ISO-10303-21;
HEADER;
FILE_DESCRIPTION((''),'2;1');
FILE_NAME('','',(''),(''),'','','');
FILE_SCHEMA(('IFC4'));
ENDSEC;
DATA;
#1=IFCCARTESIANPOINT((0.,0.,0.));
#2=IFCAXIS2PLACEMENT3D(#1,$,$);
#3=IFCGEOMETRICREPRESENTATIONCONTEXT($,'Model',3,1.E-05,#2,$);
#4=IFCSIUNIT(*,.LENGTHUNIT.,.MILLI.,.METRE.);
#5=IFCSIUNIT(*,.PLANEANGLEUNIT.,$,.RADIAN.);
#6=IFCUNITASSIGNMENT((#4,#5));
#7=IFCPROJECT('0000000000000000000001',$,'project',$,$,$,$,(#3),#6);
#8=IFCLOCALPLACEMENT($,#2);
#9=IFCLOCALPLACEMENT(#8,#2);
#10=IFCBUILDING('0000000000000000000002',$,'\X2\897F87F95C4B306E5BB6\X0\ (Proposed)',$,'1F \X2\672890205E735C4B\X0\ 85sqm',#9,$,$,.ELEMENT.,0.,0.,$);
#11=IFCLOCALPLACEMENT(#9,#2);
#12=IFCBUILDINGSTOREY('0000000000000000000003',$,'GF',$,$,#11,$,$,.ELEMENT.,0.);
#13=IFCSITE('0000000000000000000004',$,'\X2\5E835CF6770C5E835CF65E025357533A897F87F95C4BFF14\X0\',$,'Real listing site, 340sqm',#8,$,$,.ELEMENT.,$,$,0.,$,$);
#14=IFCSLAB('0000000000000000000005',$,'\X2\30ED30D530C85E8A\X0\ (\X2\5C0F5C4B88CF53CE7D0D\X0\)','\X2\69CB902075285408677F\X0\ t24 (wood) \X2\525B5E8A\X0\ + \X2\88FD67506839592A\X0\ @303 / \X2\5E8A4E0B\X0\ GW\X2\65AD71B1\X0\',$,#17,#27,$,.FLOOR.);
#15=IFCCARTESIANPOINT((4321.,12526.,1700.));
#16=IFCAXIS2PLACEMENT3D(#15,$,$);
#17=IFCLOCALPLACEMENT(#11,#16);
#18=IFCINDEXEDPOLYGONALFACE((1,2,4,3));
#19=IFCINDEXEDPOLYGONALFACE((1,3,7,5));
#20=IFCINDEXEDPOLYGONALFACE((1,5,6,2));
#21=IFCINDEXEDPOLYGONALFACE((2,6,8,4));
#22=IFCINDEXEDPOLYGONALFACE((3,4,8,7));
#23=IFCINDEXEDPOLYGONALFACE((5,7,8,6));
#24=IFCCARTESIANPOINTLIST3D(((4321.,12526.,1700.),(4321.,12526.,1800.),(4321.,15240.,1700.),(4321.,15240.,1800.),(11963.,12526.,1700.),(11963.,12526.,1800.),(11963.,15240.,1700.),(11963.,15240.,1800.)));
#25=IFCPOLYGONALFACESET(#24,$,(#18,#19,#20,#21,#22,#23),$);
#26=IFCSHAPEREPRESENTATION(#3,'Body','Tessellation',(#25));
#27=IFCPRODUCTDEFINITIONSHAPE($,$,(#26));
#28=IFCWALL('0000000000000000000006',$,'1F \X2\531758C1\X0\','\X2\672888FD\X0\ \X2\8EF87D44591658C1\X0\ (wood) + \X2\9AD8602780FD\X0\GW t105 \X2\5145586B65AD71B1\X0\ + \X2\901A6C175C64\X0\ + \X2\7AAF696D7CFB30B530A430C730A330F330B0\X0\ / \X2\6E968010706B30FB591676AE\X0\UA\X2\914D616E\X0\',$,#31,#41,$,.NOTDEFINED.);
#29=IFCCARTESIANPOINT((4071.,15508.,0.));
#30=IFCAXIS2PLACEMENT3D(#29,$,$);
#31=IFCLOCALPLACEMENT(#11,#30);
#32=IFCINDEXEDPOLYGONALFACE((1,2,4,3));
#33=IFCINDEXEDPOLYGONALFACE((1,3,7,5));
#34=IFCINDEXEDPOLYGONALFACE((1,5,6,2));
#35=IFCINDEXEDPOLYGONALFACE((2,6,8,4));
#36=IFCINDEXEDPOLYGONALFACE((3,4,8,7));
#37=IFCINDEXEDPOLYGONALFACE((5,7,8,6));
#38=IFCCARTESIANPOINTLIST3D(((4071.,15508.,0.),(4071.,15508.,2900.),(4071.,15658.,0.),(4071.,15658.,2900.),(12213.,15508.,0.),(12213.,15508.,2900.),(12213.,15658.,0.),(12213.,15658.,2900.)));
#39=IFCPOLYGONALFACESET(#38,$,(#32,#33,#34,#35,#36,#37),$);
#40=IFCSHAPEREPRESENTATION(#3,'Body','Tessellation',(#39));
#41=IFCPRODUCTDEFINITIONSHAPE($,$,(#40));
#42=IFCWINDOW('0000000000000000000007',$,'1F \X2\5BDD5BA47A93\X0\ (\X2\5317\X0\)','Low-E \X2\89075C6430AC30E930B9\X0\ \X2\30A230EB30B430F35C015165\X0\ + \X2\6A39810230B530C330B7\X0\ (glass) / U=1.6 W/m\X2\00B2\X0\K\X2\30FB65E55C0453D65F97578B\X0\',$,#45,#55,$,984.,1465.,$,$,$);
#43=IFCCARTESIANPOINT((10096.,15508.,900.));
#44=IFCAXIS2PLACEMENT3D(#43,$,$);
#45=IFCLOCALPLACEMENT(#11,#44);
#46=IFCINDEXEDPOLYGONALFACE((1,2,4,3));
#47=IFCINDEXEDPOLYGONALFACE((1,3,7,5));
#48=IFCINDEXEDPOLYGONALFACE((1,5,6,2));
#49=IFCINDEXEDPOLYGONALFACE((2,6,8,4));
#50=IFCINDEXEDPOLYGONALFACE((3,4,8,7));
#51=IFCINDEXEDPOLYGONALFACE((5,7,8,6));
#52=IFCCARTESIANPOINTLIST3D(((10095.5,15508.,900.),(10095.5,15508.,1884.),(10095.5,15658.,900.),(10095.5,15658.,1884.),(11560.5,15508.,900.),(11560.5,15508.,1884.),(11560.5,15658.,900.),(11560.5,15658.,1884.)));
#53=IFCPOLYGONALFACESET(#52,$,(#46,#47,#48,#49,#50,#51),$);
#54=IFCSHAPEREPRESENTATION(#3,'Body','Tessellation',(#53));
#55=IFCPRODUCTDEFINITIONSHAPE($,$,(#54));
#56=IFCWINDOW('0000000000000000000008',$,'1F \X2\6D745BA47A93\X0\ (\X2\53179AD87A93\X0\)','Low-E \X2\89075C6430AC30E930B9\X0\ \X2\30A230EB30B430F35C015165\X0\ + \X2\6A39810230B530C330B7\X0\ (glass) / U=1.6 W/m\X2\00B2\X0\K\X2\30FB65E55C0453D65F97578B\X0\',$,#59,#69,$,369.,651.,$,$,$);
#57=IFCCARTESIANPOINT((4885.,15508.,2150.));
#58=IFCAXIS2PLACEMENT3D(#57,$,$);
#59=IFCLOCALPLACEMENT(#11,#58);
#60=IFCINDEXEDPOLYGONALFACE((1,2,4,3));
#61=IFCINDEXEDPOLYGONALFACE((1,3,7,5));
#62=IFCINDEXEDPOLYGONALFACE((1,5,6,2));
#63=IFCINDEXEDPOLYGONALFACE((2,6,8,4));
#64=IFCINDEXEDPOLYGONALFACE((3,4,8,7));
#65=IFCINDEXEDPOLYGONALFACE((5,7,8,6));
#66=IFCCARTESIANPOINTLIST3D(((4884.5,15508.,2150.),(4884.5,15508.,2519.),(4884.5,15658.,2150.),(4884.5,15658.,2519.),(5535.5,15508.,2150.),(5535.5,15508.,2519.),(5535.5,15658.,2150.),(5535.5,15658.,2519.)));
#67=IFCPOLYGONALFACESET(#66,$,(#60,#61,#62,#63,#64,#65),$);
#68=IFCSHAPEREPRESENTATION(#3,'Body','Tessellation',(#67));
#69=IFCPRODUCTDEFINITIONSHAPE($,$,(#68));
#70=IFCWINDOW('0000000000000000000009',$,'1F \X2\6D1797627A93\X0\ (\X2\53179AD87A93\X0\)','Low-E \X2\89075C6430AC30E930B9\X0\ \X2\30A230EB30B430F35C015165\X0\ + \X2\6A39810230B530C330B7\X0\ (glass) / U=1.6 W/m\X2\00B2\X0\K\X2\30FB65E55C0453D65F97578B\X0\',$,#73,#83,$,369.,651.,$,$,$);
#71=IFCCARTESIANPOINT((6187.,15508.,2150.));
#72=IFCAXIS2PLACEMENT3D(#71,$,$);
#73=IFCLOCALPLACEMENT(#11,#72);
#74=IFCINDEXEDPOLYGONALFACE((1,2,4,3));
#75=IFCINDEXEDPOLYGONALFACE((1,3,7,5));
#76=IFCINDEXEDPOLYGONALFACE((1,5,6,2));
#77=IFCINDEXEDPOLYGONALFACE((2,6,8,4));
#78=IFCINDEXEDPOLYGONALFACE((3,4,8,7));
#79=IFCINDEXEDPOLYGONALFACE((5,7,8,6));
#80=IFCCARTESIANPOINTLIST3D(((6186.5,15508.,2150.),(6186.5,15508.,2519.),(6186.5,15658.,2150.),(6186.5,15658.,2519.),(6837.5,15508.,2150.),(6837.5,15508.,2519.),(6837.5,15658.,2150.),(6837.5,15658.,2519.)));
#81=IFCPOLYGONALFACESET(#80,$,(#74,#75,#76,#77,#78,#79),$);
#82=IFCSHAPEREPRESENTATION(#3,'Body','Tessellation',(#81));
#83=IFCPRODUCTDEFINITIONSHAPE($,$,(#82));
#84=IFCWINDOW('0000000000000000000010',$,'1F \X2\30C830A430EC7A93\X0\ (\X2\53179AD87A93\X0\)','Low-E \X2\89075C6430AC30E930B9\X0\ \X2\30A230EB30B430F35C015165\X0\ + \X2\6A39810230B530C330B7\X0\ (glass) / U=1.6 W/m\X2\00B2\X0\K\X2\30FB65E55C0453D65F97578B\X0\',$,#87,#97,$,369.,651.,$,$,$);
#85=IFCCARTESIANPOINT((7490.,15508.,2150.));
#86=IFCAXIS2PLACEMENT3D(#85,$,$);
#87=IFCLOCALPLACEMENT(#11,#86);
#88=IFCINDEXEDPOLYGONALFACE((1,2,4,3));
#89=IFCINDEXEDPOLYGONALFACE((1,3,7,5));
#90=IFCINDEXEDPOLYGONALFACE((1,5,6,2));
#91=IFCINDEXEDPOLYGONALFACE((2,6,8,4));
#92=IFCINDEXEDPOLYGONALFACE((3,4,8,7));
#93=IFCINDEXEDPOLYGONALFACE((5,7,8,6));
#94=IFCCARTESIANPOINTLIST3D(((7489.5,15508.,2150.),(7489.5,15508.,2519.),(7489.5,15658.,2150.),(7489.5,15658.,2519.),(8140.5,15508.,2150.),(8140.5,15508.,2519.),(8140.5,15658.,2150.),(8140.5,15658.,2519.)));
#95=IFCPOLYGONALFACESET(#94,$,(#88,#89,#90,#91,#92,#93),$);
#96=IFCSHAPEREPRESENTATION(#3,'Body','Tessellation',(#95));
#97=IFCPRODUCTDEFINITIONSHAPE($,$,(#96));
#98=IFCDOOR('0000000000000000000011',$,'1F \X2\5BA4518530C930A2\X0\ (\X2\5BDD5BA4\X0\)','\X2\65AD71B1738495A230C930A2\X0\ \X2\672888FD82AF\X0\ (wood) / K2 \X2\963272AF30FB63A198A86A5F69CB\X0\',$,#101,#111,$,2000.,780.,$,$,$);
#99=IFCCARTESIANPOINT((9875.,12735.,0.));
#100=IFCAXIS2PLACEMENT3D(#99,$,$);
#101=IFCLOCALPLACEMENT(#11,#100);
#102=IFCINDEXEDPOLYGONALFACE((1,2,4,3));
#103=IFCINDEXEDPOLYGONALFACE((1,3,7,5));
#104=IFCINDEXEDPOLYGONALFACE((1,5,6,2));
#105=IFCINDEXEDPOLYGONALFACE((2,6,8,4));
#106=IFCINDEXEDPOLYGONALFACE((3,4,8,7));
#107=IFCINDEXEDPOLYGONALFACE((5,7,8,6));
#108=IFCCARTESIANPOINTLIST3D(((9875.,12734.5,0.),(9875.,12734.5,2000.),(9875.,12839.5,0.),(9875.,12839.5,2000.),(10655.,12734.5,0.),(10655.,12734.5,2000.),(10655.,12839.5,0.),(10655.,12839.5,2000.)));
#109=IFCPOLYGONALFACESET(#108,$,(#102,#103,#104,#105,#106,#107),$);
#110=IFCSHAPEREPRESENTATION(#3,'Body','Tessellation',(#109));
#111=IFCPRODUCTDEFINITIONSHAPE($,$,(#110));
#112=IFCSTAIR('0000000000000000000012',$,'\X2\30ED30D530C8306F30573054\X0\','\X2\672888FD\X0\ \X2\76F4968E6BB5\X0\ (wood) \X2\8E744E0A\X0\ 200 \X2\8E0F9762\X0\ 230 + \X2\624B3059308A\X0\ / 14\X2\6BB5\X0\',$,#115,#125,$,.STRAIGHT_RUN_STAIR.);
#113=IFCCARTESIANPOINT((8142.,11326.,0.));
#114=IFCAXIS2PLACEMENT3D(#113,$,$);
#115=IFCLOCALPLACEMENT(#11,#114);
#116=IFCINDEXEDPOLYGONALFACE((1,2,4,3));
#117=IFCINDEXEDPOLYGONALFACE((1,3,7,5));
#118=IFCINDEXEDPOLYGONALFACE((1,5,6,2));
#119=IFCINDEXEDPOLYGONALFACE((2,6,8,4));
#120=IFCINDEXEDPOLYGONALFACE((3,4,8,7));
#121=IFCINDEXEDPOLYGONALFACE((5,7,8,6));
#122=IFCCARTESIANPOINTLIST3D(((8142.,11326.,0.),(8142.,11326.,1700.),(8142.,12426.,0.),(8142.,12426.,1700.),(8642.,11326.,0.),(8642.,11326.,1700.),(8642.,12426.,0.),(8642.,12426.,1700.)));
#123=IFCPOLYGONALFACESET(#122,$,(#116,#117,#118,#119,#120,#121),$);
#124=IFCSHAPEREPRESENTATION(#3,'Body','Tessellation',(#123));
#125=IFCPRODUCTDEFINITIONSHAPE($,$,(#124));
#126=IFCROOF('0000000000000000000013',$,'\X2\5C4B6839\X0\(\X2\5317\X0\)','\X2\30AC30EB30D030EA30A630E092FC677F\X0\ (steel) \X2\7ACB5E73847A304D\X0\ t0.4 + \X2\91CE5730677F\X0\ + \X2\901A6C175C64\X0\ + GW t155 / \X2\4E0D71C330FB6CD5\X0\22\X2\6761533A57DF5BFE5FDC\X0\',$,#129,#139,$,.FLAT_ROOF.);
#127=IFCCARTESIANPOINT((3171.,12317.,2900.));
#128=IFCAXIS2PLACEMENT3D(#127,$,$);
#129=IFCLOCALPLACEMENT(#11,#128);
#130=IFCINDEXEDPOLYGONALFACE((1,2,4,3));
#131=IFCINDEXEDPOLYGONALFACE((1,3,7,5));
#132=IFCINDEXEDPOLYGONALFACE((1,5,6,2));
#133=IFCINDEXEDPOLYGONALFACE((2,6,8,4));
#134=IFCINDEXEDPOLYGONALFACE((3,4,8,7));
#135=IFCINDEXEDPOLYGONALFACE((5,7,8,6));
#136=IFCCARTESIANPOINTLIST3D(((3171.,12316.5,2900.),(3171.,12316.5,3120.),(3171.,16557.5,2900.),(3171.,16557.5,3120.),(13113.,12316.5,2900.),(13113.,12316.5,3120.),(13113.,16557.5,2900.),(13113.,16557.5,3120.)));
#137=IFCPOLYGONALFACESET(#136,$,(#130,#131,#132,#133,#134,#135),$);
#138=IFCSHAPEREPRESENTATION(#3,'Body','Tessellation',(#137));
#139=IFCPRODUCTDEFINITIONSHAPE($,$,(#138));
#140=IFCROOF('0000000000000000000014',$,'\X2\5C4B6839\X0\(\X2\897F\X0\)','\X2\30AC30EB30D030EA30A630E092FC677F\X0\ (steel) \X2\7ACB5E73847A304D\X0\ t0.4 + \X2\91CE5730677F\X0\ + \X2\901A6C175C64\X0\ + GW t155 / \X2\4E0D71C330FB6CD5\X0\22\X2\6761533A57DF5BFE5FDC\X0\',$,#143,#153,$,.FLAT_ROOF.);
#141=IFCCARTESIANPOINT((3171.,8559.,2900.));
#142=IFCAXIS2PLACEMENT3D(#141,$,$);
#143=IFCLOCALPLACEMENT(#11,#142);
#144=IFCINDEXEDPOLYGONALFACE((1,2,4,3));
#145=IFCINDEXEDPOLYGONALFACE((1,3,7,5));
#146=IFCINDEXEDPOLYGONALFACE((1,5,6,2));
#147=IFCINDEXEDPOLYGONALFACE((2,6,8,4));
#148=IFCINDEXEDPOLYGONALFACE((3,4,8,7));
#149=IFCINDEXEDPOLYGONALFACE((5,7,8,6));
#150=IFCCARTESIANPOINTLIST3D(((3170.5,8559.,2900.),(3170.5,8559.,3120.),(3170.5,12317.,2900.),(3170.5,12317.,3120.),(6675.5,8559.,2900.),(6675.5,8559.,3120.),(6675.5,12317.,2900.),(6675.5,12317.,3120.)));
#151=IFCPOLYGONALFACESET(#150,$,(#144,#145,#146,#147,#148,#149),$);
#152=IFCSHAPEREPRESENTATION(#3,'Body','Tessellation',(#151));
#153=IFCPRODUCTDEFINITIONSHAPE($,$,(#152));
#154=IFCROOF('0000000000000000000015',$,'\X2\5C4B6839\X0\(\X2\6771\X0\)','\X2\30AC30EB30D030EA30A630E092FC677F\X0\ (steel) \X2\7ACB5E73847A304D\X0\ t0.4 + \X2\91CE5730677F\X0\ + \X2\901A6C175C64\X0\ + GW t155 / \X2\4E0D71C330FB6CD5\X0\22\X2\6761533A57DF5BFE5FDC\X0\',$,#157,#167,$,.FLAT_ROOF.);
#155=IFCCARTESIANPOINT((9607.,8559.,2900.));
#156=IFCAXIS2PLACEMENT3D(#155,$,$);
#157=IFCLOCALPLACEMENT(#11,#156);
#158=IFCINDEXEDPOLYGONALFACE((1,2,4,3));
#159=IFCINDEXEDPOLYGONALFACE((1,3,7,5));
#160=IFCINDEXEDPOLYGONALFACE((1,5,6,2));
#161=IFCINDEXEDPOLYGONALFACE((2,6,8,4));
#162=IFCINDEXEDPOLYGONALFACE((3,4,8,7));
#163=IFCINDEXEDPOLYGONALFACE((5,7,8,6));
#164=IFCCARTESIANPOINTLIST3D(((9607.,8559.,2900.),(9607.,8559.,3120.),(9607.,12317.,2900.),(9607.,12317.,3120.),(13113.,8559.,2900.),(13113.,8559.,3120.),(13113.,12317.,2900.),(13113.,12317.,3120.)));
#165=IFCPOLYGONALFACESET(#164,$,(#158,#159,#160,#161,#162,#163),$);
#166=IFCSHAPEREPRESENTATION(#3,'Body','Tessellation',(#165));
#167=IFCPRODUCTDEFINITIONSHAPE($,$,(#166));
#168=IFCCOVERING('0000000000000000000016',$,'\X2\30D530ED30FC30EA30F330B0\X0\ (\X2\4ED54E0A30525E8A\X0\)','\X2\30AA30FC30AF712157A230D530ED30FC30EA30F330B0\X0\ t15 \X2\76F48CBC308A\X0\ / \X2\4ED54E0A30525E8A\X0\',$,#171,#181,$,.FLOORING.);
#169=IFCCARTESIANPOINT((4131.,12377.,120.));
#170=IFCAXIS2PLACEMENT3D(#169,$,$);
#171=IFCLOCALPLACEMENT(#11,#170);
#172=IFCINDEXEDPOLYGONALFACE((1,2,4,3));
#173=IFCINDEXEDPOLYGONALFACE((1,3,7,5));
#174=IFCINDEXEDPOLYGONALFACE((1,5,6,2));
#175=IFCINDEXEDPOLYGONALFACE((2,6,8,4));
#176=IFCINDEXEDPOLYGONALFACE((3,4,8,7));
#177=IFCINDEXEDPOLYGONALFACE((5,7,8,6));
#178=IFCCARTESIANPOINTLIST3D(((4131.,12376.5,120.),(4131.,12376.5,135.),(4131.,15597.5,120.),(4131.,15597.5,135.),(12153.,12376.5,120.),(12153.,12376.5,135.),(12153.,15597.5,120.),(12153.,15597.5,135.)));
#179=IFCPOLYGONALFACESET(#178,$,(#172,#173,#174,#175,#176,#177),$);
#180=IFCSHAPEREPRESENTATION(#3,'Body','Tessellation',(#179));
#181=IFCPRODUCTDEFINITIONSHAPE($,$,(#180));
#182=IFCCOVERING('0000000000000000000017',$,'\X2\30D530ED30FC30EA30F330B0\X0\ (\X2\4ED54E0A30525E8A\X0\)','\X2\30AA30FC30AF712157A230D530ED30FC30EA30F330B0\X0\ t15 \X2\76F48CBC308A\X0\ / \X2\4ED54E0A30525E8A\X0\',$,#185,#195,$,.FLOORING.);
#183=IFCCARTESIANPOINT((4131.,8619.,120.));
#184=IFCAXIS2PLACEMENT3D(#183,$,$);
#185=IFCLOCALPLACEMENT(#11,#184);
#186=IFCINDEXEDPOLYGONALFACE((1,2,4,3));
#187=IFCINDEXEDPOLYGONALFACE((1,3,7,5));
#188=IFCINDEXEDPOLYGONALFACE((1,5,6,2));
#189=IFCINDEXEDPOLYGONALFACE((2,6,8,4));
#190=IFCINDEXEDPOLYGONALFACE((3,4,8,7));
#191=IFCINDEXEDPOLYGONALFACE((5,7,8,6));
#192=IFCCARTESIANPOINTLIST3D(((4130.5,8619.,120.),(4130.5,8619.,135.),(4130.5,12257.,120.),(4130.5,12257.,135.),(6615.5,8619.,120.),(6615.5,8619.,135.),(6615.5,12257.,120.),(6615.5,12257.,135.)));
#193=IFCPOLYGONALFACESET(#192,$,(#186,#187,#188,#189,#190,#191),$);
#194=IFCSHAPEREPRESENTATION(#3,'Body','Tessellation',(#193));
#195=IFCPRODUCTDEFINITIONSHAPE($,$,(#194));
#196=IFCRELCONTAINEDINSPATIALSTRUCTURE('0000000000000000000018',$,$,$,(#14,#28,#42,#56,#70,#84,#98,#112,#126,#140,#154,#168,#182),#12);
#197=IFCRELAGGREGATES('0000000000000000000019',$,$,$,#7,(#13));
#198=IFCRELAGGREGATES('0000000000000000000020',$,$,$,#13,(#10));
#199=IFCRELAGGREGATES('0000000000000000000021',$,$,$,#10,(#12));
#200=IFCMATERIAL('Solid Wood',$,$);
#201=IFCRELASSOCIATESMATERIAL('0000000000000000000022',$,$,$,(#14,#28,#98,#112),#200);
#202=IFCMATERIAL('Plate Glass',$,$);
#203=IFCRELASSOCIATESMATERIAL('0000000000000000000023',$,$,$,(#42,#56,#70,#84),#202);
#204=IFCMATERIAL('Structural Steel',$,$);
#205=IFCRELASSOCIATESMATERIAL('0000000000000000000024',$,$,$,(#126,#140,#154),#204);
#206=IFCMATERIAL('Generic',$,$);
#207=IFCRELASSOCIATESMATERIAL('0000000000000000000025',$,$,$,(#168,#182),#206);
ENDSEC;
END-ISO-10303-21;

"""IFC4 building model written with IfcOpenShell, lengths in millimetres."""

from ifc_helpers import new_model, si_unit, frame, frame_2d, origin, place, context, project, spatial, rectangle, extrude, material, element, fill, save


model = new_model("IFC4")

# Units and contexts
model_context = context("Model", 3, precision=1e-05, world=origin())
ifc_project = project(units=[si_unit("LENGTHUNIT", "METRE", prefix="MILLI"), si_unit("PLANEANGLEUNIT", "RADIAN")], contexts=[model_context])

# Site, building, storey
site_placement = place(None, origin())
site = spatial("IfcSite", under=ifc_project, at=site_placement, Name="広島県広島市南区西蟹屋４", ObjectType="Real listing site, 340sqm", CompositionType="ELEMENT", RefElevation=0.0)
building_placement = place(site_placement, origin())
building = spatial("IfcBuilding", under=site, at=building_placement, Name="西蟹屋の家 (Proposed)", ObjectType="1F 木造平屋 85sqm", CompositionType="ELEMENT", ElevationOfRefHeight=0.0, ElevationOfTerrain=0.0)
storey_placement = place(building_placement, origin())
storey = spatial("IfcBuildingStorey", under=building, at=storey_placement, Name="GF", CompositionType="ELEMENT", Elevation=0.0)

# Slab
ifc_material_1 = material(Name="Solid Wood")
slab_1_placement = place(storey_placement, frame((4321.0, 12526.0, 1700.0)))
element("IfcSlab", 1, at=slab_1_placement, inside=storey, material=ifc_material_1, Name="ロフト床 (小屋裏収納)", Description="構造用合板 t24 (wood) 剛床 + 製材根太 @303 / 床下 GW断熱", PredefinedType="FLOOR", context=model_context, shape_type="SweptSolid", body=[
    extrude(rectangle(XDim=7642.0, YDim=2714.0, at=frame_2d((3821.0, 1357.0))), frame((4321.0, 12526.0, 1700.0)), (0.0, 0.0, 1.0), 100.0),
])

# Wall, openings, windows
wall_1_placement = place(storey_placement, frame((4071.0, 15508.0, 0.0)))
wall_1 = element("IfcWall", 2, at=wall_1_placement, inside=storey, material=ifc_material_1, Name="1F 北壁", Description="木製 軸組外壁 (wood) + 高性能GW t105 充填断熱 + 通気層 + 窯業系サイディング / 準耐火・外皮UA配慮", PredefinedType="NOTDEFINED", context=model_context, shape_type="SweptSolid", body=[
    extrude(rectangle(XDim=8142.0, YDim=150.0, at=frame_2d((4071.0, 75.0))), frame((4071.0, 15508.0, 0.0)), (0.0, 0.0, 1.0), 2900.0),
])
opening_1_placement = place(storey_placement, frame((10096.0, 15508.0, 900.0)))
opening_1 = element("IfcOpeningElement", 3, at=opening_1_placement, cuts=wall_1, PredefinedType="NOTDEFINED", context=model_context, shape_type="SweptSolid", body=[
    extrude(rectangle(XDim=1465.0, YDim=150.0, at=frame_2d((732.0, 75.0))), frame((10096.0, 15508.0, 900.0)), (0.0, 0.0, 1.0), 984.0),
])
opening_2_placement = place(storey_placement, frame((4885.0, 15508.0, 2150.0)))
opening_2 = element("IfcOpeningElement", 4, at=opening_2_placement, cuts=wall_1, PredefinedType="NOTDEFINED", context=model_context, shape_type="SweptSolid", body=[
    extrude(rectangle(XDim=651.0, YDim=150.0, at=frame_2d((325.0, 75.0))), frame((4885.0, 15508.0, 2150.0)), (0.0, 0.0, 1.0), 369.0),
])
opening_3_placement = place(storey_placement, frame((6187.0, 15508.0, 2150.0)))
opening_3 = element("IfcOpeningElement", 5, at=opening_3_placement, cuts=wall_1, PredefinedType="NOTDEFINED", context=model_context, shape_type="SweptSolid", body=[
    extrude(rectangle(XDim=651.0, YDim=150.0, at=frame_2d((325.0, 75.0))), frame((6187.0, 15508.0, 2150.0)), (0.0, 0.0, 1.0), 369.0),
])
opening_4_placement = place(storey_placement, frame((7490.0, 15508.0, 2150.0)))
opening_4 = element("IfcOpeningElement", 6, at=opening_4_placement, cuts=wall_1, PredefinedType="NOTDEFINED", context=model_context, shape_type="SweptSolid", body=[
    extrude(rectangle(XDim=651.0, YDim=150.0, at=frame_2d((325.0, 75.0))), frame((7490.0, 15508.0, 2150.0)), (0.0, 0.0, 1.0), 369.0),
])
ifc_material_2 = material(Name="Plate Glass")
window_1_placement = place(storey_placement, frame((10096.0, 15508.0, 900.0)))
window_1 = element("IfcWindow", 7, at=window_1_placement, inside=storey, material=ifc_material_2, Name="1F 寝室窓 (北)", Description="Low-E 複層ガラス アルゴン封入 + 樹脂サッシ (glass) / U=1.6 W/m²K・日射取得型", OverallHeight=984.0, OverallWidth=1465.0, context=model_context, shape_type="SweptSolid", body=[
    extrude(rectangle(XDim=1465.0, YDim=150.0, at=frame_2d((732.0, 75.0))), frame((10096.0, 15508.0, 900.0)), (0.0, 0.0, 1.0), 984.0),
])
fill(opening_1, window_1)
window_2_placement = place(storey_placement, frame((4885.0, 15508.0, 2150.0)))
window_2 = element("IfcWindow", 8, at=window_2_placement, inside=storey, material=ifc_material_2, Name="1F 浴室窓 (北高窓)", Description="Low-E 複層ガラス アルゴン封入 + 樹脂サッシ (glass) / U=1.6 W/m²K・日射取得型", OverallHeight=369.0, OverallWidth=651.0, context=model_context, shape_type="SweptSolid", body=[
    extrude(rectangle(XDim=651.0, YDim=150.0, at=frame_2d((325.0, 75.0))), frame((4885.0, 15508.0, 2150.0)), (0.0, 0.0, 1.0), 369.0),
])
fill(opening_2, window_2)
window_3_placement = place(storey_placement, frame((6187.0, 15508.0, 2150.0)))
window_3 = element("IfcWindow", 9, at=window_3_placement, inside=storey, material=ifc_material_2, Name="1F 洗面窓 (北高窓)", Description="Low-E 複層ガラス アルゴン封入 + 樹脂サッシ (glass) / U=1.6 W/m²K・日射取得型", OverallHeight=369.0, OverallWidth=651.0, context=model_context, shape_type="SweptSolid", body=[
    extrude(rectangle(XDim=651.0, YDim=150.0, at=frame_2d((325.0, 75.0))), frame((6187.0, 15508.0, 2150.0)), (0.0, 0.0, 1.0), 369.0),
])
fill(opening_3, window_3)
window_4_placement = place(storey_placement, frame((7490.0, 15508.0, 2150.0)))
window_4 = element("IfcWindow", 10, at=window_4_placement, inside=storey, material=ifc_material_2, Name="1F トイレ窓 (北高窓)", Description="Low-E 複層ガラス アルゴン封入 + 樹脂サッシ (glass) / U=1.6 W/m²K・日射取得型", OverallHeight=369.0, OverallWidth=651.0, context=model_context, shape_type="SweptSolid", body=[
    extrude(rectangle(XDim=651.0, YDim=150.0, at=frame_2d((325.0, 75.0))), frame((7490.0, 15508.0, 2150.0)), (0.0, 0.0, 1.0), 369.0),
])
fill(opening_4, window_4)

# Door
door_1_placement = place(storey_placement, frame((9875.0, 12735.0, 0.0)))
element("IfcDoor", 11, at=door_1_placement, inside=storey, material=ifc_material_1, Name="1F 室内ドア (寝室)", Description="断熱玄関ドア 木製芯 (wood) / K2 防犯・採風機構", OverallHeight=2000.0, OverallWidth=780.0, context=model_context, shape_type="SweptSolid", body=[
    extrude(rectangle(XDim=780.0, YDim=105.0, at=frame_2d((390.0, 52.0))), frame((9875.0, 12735.0, 0.0)), (0.0, 0.0, 1.0), 2000.0),
])

# Stair
stair_placement = place(storey_placement, frame((8142.0, 11326.0, 0.0)))
element("IfcStair", 12, at=stair_placement, inside=storey, material=ifc_material_1, Name="ロフトはしご", Description="木製 直階段 (wood) 蹴上 200 踏面 230 + 手すり / 14段", PredefinedType="STRAIGHT_RUN_STAIR", context=model_context, shape_type="SweptSolid", body=[
    extrude(rectangle(XDim=500.0, YDim=1100.0, at=frame_2d((250.0, 550.0))), frame((8142.0, 11326.0, 0.0)), (0.0, 0.0, 1.0), 1700.0),
])

# Roofs
ifc_material_3 = material(Name="Structural Steel")
roof_1_placement = place(storey_placement, frame((3171.0, 12317.0, 2900.0)))
element("IfcRoof", 13, at=roof_1_placement, inside=storey, material=ifc_material_3, Name="屋根(北)", Description="ガルバリウム鋼板 (steel) 立平葺き t0.4 + 野地板 + 通気層 + GW t155 / 不燃・法22条区域対応", PredefinedType="FLAT_ROOF", context=model_context, shape_type="SweptSolid", body=[
    extrude(rectangle(XDim=9942.0, YDim=4241.0, at=frame_2d((4971.0, 2120.0))), frame((3171.0, 12317.0, 2900.0)), (0.0, 0.0, 1.0), 220.0),
])
roof_2_placement = place(storey_placement, frame((3171.0, 8559.0, 2900.0)))
element("IfcRoof", 14, at=roof_2_placement, inside=storey, material=ifc_material_3, Name="屋根(西)", Description="ガルバリウム鋼板 (steel) 立平葺き t0.4 + 野地板 + 通気層 + GW t155 / 不燃・法22条区域対応", PredefinedType="FLAT_ROOF", context=model_context, shape_type="SweptSolid", body=[
    extrude(rectangle(XDim=3505.0, YDim=3758.0, at=frame_2d((1752.0, 1879.0))), frame((3171.0, 8559.0, 2900.0)), (0.0, 0.0, 1.0), 220.0),
])
roof_3_placement = place(storey_placement, frame((9607.0, 8559.0, 2900.0)))
element("IfcRoof", 15, at=roof_3_placement, inside=storey, material=ifc_material_3, Name="屋根(東)", Description="ガルバリウム鋼板 (steel) 立平葺き t0.4 + 野地板 + 通気層 + GW t155 / 不燃・法22条区域対応", PredefinedType="FLAT_ROOF", context=model_context, shape_type="SweptSolid", body=[
    extrude(rectangle(XDim=3506.0, YDim=3758.0, at=frame_2d((1753.0, 1879.0))), frame((9607.0, 8559.0, 2900.0)), (0.0, 0.0, 1.0), 220.0),
])

# Coverings
ifc_material_4 = material(Name="Generic")
covering_1_placement = place(storey_placement, frame((4131.0, 12377.0, 120.0)))
element("IfcCovering", 16, at=covering_1_placement, inside=storey, material=ifc_material_4, Name="フローリング (仕上げ床)", Description="オーク無垢フローリング t15 直貼り / 仕上げ床", PredefinedType="FLOORING", context=model_context, shape_type="SweptSolid", body=[
    extrude(rectangle(XDim=8022.0, YDim=3221.0, at=frame_2d((4011.0, 1610.0))), frame((4131.0, 12377.0, 120.0)), (0.0, 0.0, 1.0), 15.0),
])
covering_2_placement = place(storey_placement, frame((4131.0, 8619.0, 120.0)))
element("IfcCovering", 17, at=covering_2_placement, inside=storey, material=ifc_material_4, Name="フローリング (仕上げ床)", Description="オーク無垢フローリング t15 直貼り / 仕上げ床", PredefinedType="FLOORING", context=model_context, shape_type="SweptSolid", body=[
    extrude(rectangle(XDim=2485.0, YDim=3638.0, at=frame_2d((1242.0, 1819.0))), frame((4131.0, 8619.0, 120.0)), (0.0, 0.0, 1.0), 15.0),
])

save(model, "model.ifc")
